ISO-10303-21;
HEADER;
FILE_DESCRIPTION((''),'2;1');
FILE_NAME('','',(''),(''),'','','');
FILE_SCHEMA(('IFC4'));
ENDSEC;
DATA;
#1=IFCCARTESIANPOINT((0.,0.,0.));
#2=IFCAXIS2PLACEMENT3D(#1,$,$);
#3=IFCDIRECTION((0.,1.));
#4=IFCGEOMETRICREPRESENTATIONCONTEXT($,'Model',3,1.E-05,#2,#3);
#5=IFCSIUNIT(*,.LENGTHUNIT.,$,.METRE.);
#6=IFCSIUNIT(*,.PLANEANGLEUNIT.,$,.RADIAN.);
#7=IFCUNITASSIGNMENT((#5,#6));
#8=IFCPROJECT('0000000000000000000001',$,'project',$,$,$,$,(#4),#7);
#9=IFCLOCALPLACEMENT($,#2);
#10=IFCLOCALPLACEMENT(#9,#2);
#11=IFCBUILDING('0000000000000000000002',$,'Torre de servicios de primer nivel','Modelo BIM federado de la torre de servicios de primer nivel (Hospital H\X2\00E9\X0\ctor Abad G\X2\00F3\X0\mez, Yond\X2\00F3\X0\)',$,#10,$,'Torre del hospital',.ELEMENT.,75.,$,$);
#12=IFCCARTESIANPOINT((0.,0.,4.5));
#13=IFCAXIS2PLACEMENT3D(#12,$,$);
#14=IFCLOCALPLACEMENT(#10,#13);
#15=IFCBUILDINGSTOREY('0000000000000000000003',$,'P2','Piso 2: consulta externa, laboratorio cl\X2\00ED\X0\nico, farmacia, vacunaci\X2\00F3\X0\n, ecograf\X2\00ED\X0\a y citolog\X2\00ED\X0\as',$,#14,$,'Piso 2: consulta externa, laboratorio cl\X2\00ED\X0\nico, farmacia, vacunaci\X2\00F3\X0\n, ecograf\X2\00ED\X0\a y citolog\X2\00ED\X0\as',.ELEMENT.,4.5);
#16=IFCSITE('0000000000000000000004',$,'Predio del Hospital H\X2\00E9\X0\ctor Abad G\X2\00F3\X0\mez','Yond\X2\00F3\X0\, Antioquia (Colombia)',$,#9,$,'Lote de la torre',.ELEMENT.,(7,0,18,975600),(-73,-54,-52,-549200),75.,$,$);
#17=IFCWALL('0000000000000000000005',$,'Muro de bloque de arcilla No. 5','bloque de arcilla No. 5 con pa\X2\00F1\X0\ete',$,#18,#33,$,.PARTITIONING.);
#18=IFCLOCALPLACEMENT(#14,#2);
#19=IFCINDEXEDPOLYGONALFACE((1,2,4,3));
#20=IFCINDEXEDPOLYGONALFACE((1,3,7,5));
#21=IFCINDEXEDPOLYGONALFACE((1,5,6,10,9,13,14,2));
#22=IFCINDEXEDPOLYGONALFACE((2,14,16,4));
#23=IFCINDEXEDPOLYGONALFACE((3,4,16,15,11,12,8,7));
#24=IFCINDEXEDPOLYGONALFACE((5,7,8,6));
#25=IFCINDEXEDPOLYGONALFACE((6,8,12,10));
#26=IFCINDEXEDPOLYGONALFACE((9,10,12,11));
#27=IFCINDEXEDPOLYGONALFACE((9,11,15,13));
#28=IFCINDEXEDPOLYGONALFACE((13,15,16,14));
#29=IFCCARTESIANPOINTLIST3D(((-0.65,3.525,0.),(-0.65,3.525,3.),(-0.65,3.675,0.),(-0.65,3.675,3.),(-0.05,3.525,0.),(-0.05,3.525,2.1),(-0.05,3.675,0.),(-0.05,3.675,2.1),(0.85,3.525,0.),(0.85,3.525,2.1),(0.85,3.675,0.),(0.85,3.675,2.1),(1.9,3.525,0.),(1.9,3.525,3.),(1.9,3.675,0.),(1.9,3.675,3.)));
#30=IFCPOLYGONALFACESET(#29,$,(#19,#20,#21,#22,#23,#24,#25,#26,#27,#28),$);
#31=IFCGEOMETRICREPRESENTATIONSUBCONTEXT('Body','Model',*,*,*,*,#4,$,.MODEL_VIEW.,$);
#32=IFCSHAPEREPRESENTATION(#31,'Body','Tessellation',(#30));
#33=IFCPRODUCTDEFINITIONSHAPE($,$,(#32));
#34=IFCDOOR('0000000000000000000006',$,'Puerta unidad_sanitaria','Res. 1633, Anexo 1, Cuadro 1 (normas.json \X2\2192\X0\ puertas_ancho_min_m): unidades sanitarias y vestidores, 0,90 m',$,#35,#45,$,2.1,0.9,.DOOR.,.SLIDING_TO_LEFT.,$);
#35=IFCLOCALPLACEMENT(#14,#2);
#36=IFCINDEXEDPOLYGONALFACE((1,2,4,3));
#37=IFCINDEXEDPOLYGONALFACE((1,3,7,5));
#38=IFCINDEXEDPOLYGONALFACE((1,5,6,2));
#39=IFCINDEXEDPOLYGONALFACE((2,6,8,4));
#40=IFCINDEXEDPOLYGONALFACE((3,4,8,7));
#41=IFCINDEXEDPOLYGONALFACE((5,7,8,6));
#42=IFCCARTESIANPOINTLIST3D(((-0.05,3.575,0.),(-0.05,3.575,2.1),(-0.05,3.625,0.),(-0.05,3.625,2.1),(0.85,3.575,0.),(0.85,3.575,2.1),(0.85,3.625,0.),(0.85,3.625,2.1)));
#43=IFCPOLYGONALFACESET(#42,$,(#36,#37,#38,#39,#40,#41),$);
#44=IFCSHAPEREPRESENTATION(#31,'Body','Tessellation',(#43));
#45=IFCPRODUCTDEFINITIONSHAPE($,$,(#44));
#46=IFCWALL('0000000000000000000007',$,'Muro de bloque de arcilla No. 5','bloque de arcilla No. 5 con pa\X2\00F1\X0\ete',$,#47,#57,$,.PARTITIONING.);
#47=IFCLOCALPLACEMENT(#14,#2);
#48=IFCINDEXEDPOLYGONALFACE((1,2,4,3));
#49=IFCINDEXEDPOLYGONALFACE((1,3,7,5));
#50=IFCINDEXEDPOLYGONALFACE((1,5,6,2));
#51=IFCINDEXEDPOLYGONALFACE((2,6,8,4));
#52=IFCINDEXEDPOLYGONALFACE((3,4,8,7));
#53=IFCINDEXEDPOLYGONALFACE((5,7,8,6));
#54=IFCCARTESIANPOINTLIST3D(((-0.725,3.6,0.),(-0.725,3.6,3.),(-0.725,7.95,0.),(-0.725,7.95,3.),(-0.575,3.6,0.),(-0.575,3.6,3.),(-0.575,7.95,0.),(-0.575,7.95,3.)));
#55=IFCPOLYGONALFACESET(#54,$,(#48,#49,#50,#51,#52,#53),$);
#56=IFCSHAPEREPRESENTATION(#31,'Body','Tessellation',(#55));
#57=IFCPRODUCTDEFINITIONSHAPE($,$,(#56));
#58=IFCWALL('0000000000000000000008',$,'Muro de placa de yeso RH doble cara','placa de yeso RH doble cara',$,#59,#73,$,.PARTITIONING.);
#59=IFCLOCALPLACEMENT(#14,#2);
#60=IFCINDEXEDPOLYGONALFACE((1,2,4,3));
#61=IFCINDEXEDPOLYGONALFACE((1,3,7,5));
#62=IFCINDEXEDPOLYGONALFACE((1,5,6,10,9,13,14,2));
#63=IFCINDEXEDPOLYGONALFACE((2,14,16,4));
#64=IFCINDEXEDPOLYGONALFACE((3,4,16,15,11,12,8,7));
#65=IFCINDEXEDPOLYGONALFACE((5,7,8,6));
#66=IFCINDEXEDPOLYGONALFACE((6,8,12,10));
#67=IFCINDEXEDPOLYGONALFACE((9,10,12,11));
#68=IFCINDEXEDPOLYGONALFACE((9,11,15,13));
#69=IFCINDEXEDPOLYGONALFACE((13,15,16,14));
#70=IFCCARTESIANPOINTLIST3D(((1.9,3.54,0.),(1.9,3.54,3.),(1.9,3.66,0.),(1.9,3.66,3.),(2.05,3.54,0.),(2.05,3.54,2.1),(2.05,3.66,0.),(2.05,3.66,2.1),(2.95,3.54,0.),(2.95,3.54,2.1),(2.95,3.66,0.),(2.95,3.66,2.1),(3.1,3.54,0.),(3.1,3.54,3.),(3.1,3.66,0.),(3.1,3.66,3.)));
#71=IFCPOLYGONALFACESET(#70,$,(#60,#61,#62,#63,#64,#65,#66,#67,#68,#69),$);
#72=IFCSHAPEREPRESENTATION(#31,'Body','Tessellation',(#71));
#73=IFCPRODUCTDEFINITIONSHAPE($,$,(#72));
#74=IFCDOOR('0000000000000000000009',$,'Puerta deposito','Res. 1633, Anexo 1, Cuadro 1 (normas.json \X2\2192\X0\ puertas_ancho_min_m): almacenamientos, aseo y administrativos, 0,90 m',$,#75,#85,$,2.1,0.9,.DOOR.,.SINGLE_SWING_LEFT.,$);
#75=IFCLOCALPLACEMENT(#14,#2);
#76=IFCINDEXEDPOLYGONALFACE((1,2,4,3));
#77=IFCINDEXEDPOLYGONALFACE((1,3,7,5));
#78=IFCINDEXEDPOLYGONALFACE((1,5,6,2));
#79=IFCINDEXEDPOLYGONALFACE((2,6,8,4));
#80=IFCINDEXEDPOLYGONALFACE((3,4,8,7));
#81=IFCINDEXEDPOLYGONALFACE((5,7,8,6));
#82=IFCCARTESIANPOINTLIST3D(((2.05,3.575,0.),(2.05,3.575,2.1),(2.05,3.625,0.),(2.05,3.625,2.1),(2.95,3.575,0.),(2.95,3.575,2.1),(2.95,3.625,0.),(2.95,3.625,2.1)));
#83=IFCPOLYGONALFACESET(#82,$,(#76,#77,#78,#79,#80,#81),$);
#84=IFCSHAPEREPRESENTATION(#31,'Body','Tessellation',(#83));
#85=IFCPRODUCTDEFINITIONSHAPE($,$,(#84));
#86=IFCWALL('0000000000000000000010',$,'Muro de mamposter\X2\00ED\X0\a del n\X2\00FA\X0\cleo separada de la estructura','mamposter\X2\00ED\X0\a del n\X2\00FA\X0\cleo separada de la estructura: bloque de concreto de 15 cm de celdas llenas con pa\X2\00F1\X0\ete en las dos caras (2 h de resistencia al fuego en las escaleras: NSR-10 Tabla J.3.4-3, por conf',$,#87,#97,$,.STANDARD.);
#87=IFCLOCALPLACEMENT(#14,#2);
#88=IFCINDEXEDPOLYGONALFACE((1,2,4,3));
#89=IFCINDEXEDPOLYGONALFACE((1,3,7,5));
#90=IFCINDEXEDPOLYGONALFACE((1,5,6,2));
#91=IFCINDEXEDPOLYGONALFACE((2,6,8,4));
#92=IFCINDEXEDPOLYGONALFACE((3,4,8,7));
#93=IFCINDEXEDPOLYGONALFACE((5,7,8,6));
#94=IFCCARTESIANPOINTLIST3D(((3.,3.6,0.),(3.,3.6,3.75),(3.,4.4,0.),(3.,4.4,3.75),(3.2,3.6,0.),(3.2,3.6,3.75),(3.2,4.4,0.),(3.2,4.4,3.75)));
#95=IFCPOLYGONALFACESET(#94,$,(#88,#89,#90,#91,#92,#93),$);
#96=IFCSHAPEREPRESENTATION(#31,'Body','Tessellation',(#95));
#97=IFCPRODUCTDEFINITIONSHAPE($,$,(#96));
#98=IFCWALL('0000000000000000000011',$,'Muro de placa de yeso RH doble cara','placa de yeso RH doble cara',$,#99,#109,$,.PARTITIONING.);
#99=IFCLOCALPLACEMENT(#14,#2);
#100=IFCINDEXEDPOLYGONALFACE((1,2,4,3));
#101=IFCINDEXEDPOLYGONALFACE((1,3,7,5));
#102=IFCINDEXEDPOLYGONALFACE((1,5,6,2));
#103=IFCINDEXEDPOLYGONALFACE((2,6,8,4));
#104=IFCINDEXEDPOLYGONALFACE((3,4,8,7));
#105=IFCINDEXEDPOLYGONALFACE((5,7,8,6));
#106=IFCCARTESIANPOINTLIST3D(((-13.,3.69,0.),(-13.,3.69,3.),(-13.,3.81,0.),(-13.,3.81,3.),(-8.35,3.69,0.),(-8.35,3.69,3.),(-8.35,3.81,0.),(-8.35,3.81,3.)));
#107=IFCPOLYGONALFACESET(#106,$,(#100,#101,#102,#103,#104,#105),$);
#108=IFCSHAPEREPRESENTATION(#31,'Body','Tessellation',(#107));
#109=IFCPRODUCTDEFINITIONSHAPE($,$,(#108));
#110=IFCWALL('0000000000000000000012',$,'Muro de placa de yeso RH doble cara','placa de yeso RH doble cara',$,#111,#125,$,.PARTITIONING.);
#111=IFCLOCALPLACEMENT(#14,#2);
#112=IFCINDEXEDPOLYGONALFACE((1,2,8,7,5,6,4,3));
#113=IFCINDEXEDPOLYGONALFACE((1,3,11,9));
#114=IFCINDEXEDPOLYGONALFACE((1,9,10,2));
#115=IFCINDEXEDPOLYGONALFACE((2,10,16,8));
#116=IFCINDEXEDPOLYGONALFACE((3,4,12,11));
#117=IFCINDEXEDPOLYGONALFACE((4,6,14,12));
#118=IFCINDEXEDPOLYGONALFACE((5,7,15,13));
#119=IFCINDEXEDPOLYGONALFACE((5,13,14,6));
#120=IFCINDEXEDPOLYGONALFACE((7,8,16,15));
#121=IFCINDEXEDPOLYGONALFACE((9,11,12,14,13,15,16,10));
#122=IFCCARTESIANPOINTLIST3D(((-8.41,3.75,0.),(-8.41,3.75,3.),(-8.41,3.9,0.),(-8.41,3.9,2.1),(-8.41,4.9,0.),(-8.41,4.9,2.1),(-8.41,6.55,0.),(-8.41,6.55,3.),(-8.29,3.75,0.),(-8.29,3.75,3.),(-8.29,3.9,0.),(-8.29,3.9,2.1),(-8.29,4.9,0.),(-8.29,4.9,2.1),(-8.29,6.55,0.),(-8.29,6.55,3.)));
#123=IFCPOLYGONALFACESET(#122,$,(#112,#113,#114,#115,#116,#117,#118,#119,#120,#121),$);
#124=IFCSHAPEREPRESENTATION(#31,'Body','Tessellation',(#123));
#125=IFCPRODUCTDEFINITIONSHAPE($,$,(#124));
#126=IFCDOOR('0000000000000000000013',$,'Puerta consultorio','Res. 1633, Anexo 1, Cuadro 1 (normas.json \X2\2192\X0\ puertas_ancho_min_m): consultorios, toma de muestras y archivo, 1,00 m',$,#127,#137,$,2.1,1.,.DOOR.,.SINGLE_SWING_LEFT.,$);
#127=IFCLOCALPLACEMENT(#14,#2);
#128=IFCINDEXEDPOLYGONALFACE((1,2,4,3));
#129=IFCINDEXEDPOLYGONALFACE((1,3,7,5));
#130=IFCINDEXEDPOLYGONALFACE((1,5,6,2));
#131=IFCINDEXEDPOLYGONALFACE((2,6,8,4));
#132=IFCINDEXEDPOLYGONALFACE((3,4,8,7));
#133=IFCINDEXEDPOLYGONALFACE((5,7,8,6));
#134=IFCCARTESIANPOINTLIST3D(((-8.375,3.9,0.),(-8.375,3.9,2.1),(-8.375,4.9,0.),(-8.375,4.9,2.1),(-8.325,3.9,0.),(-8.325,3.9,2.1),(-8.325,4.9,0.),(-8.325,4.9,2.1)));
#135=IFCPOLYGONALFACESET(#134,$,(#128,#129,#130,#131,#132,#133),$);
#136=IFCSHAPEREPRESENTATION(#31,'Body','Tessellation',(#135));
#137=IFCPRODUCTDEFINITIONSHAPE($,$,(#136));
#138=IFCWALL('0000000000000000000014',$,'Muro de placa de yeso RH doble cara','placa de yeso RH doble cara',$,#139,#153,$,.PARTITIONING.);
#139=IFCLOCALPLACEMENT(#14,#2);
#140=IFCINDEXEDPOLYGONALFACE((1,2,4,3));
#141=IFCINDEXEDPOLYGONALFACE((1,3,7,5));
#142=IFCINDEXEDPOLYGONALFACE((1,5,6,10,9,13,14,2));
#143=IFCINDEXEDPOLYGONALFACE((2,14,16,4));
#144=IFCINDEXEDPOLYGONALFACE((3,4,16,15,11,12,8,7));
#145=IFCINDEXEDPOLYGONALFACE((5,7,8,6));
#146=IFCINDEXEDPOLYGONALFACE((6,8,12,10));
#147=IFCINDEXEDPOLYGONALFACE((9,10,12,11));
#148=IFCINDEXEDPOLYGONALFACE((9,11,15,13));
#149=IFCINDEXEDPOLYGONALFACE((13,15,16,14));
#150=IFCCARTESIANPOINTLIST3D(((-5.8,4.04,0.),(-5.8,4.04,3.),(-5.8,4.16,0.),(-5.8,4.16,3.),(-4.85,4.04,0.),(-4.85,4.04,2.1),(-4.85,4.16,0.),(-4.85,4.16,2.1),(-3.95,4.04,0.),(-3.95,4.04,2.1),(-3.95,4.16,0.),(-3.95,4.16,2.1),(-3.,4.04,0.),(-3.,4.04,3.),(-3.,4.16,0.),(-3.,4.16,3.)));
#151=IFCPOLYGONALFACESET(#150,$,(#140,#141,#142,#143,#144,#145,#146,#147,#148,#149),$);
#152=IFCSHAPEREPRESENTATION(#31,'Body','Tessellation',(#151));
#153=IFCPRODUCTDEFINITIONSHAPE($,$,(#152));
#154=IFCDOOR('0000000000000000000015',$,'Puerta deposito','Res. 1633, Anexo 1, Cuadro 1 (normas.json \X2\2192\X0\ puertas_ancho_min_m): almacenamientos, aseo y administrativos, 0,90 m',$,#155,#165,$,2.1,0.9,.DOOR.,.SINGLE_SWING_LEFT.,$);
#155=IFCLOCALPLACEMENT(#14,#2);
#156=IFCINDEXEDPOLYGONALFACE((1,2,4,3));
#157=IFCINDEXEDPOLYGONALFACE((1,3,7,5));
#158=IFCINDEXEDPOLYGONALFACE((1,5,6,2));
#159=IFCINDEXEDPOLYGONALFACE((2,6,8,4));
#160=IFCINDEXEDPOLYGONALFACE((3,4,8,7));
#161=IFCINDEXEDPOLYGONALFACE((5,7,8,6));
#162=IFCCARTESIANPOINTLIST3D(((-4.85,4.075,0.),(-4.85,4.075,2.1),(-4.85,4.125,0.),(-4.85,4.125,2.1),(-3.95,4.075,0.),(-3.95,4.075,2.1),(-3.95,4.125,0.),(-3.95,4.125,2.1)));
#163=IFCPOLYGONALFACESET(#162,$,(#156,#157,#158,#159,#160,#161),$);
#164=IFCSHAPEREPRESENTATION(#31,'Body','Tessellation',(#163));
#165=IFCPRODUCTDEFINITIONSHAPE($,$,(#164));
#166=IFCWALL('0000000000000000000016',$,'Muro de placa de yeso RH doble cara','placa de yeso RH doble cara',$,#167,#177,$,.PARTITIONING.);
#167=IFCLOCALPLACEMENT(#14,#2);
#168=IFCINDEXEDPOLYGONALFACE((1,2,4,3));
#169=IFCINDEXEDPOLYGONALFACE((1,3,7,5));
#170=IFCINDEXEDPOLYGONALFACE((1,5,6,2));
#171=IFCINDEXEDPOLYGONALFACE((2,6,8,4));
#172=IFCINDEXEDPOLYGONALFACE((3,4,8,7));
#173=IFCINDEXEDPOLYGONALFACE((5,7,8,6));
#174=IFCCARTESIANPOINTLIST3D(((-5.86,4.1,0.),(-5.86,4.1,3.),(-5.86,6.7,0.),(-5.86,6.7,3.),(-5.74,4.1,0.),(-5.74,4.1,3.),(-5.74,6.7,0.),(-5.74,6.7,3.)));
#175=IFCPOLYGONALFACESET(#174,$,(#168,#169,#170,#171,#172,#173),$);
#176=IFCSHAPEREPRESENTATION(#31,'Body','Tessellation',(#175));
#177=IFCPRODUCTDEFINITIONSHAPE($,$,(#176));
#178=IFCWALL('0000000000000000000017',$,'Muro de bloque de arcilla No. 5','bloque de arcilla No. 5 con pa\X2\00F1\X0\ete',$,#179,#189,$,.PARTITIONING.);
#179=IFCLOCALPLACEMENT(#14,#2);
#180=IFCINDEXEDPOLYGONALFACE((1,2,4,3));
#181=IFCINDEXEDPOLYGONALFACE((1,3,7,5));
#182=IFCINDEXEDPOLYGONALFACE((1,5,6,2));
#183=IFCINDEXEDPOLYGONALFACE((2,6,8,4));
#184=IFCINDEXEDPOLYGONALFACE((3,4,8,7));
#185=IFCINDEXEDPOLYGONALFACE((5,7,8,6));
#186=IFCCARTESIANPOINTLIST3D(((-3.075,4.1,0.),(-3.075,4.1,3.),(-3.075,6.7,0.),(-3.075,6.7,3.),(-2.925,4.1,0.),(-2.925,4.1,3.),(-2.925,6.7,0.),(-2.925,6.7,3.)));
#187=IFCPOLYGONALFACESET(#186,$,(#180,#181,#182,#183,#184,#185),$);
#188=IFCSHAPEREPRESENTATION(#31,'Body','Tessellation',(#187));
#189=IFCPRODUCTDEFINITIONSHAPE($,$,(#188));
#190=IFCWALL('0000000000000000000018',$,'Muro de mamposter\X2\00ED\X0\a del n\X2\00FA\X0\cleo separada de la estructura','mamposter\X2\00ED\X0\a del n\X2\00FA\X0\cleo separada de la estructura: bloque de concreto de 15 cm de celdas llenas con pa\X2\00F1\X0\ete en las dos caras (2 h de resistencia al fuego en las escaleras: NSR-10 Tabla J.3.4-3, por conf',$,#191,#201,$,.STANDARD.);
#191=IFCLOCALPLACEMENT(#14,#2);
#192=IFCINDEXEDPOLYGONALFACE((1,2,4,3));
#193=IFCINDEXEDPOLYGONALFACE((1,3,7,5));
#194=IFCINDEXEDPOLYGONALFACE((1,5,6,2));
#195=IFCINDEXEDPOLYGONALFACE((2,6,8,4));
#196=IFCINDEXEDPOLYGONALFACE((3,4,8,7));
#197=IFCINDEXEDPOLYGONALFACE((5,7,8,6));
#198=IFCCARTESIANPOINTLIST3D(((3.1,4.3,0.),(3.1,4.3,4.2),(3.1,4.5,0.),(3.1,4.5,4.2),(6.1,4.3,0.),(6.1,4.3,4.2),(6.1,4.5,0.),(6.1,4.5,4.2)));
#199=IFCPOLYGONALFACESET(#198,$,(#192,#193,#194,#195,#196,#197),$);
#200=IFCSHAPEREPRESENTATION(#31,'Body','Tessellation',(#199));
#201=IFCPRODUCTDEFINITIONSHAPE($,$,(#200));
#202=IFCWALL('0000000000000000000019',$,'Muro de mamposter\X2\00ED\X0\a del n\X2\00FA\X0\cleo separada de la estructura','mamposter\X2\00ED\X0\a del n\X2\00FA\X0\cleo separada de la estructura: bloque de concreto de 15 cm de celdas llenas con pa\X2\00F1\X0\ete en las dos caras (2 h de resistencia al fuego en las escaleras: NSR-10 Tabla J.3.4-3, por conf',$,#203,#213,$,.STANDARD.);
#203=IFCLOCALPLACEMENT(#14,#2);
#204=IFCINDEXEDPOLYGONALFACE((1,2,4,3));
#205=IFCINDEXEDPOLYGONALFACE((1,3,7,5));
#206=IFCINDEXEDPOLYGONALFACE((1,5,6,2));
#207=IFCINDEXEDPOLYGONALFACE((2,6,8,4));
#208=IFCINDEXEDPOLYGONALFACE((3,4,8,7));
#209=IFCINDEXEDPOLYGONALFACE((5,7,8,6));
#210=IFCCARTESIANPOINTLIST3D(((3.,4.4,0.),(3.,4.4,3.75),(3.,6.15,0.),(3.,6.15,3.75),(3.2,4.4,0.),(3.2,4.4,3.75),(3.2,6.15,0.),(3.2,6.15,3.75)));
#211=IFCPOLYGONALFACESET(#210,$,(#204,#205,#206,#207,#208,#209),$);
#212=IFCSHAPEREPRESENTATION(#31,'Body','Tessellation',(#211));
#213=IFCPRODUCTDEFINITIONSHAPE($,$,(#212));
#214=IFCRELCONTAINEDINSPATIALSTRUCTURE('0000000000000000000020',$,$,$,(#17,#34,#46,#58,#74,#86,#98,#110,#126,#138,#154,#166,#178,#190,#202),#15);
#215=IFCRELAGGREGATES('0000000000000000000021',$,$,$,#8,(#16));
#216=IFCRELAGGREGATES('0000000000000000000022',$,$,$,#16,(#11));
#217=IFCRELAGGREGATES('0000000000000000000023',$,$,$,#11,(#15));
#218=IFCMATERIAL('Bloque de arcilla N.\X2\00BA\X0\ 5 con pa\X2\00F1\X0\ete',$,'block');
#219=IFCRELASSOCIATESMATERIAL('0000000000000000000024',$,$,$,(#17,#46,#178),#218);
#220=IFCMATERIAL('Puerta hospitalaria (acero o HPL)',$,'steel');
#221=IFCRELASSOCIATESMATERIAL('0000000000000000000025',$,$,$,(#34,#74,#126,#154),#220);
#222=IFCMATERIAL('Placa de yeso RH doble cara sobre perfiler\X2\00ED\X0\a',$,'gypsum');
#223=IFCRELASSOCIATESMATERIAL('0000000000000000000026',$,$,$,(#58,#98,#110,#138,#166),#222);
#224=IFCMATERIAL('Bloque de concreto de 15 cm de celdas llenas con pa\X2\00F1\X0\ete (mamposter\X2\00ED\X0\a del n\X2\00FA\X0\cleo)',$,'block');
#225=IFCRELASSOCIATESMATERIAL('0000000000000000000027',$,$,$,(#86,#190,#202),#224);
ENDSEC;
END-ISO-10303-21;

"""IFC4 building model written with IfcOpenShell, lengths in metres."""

from ifc_helpers import new_model, si_unit, direction, frame, origin, place, context, subcontext, project, spatial, rectangle, extrude, material, element, fill, save


model = new_model("IFC4")

# Units and contexts
model_context = context("Model", 3, precision=1e-05, world=origin(), true_north=direction((0.0, 1.0)))
body_context = subcontext(model_context, "Body", "Model", "MODEL_VIEW")
ifc_project = project(units=[si_unit("LENGTHUNIT", "METRE"), si_unit("PLANEANGLEUNIT", "RADIAN")], contexts=[model_context])

# Site, building, storey
site_placement = place(None, origin())
site = spatial("IfcSite", under=ifc_project, at=site_placement, Name="Predio del Hospital Héctor Abad Gómez", Description="Yondó, Antioquia (Colombia)", LongName="Lote de la torre", CompositionType="ELEMENT", RefLatitude=(7, 0, 18, 975600), RefLongitude=(-73, -54, -52, -549200), RefElevation=75.0)
building_placement = place(site_placement, origin())
building = spatial("IfcBuilding", under=site, at=building_placement, Name="Torre de servicios de primer nivel", Description="Modelo BIM federado de la torre de servicios de primer nivel (Hospital Héctor Abad Gómez, Yondó)", LongName="Torre del hospital", CompositionType="ELEMENT", ElevationOfRefHeight=75.0)
placement = place(building_placement, frame((0.0, 0.0, 4.5)))
storey = spatial("IfcBuildingStorey", under=building, at=placement, Name="P2", Description="Piso 2: consulta externa, laboratorio clínico, farmacia, vacunación, ecografía y citologías", LongName="Piso 2: consulta externa, laboratorio clínico, farmacia, vacunación, ecografía y citologías", CompositionType="ELEMENT", Elevation=4.5)

# Wall, opening, door
ifc_material_1 = material(Name="Bloque de arcilla N.º 5 con pañete", Category="block")
wall_1 = element("IfcWall", 1, at=placement, inside=storey, material=ifc_material_1, Name="Muro de bloque de arcilla No. 5", Description="bloque de arcilla No. 5 con pañete", PredefinedType="PARTITIONING", context=body_context, shape_type="SweptSolid", body=[
    extrude(rectangle(XDim=2.55, YDim=0.15), frame((0.625, 3.6, 0.0)), (0.0, 0.0, 1.0), 3.0),
])
opening_1 = element("IfcOpeningElement", 2, at=placement, cuts=wall_1, PredefinedType="OPENING", context=body_context, shape_type="SweptSolid", body=[
    extrude(rectangle(XDim=0.9, YDim=0.25), frame((0.4, 3.6, 0.0)), (0.0, 0.0, 1.0), 2.1),
])
ifc_material_2 = material(Name="Puerta hospitalaria (acero o HPL)", Category="steel")
door_1 = element("IfcDoor", 3, at=placement, inside=storey, material=ifc_material_2, Name="Puerta unidad_sanitaria", Description="Res. 1633, Anexo 1, Cuadro 1 (normas.json → puertas_ancho_min_m): unidades sanitarias y vestidores, 0,90 m", OperationType="SLIDING_TO_LEFT", OverallHeight=2.1, OverallWidth=0.9, PredefinedType="DOOR", context=body_context, shape_type="SweptSolid", body=[
    extrude(rectangle(XDim=0.9, YDim=0.05), frame((0.4, 3.6, 0.0)), (0.0, 0.0, 1.0), 2.1),
])
fill(opening_1, door_1)

# Wall
element("IfcWall", 4, at=placement, inside=storey, material=ifc_material_1, Name="Muro de bloque de arcilla No. 5", Description="bloque de arcilla No. 5 con pañete", PredefinedType="PARTITIONING", context=body_context, shape_type="SweptSolid", body=[
    extrude(rectangle(XDim=0.15, YDim=4.35), frame((-0.65, 5.775, 0.0)), (0.0, 0.0, 1.0), 3.0),
])

# Wall, opening, door
ifc_material_3 = material(Name="Placa de yeso RH doble cara sobre perfilería", Category="gypsum")
wall_2 = element("IfcWall", 5, at=placement, inside=storey, material=ifc_material_3, Name="Muro de placa de yeso RH doble cara", Description="placa de yeso RH doble cara", PredefinedType="PARTITIONING", context=body_context, shape_type="SweptSolid", body=[
    extrude(rectangle(XDim=1.2, YDim=0.12), frame((2.5, 3.6, 0.0)), (0.0, 0.0, 1.0), 3.0),
])
opening_2 = element("IfcOpeningElement", 6, at=placement, cuts=wall_2, PredefinedType="OPENING", context=body_context, shape_type="SweptSolid", body=[
    extrude(rectangle(XDim=0.9, YDim=0.22), frame((2.5, 3.6, 0.0)), (0.0, 0.0, 1.0), 2.1),
])
door_2 = element("IfcDoor", 7, at=placement, inside=storey, material=ifc_material_2, Name="Puerta deposito", Description="Res. 1633, Anexo 1, Cuadro 1 (normas.json → puertas_ancho_min_m): almacenamientos, aseo y administrativos, 0,90 m", OperationType="SINGLE_SWING_LEFT", OverallHeight=2.1, OverallWidth=0.9, PredefinedType="DOOR", context=body_context, shape_type="SweptSolid", body=[
    extrude(rectangle(XDim=0.9, YDim=0.05), frame((2.5, 3.6, 0.0)), (0.0, 0.0, 1.0), 2.1),
])
fill(opening_2, door_2)

# Walls
ifc_material_4 = material(Name="Bloque de concreto de 15 cm de celdas llenas con pañete (mampostería del núcleo)", Category="block")
element("IfcWall", 8, at=placement, inside=storey, material=ifc_material_4, Name="Muro de mampostería del núcleo separada de la estructura", Description="mampostería del núcleo separada de la estructura: bloque de concreto de 15 cm de celdas llenas con pañete en las dos caras (2 h de resistencia al fuego en las escaleras: NSR-10 Tabla J.3.4-3, por conf", PredefinedType="STANDARD", context=body_context, shape_type="SweptSolid", body=[
    extrude(rectangle(XDim=0.2, YDim=0.8), frame((3.1, 4.0, 0.0)), (0.0, 0.0, 1.0), 3.75),
])
element("IfcWall", 9, at=placement, inside=storey, material=ifc_material_3, Name="Muro de placa de yeso RH doble cara", Description="placa de yeso RH doble cara", PredefinedType="PARTITIONING", context=body_context, shape_type="SweptSolid", body=[
    extrude(rectangle(XDim=4.65, YDim=0.12), frame((-10.675, 3.75, 0.0)), (0.0, 0.0, 1.0), 3.0),
])

# Walls, openings, doors
wall_3 = element("IfcWall", 10, at=placement, inside=storey, material=ifc_material_3, Name="Muro de placa de yeso RH doble cara", Description="placa de yeso RH doble cara", PredefinedType="PARTITIONING", context=body_context, shape_type="SweptSolid", body=[
    extrude(rectangle(XDim=0.12, YDim=2.8), frame((-8.35, 5.15, 0.0)), (0.0, 0.0, 1.0), 3.0),
])
opening_3 = element("IfcOpeningElement", 11, at=placement, cuts=wall_3, PredefinedType="OPENING", context=body_context, shape_type="SweptSolid", body=[
    extrude(rectangle(XDim=0.22, YDim=1.0), frame((-8.35, 4.4, 0.0)), (0.0, 0.0, 1.0), 2.1),
])
door_3 = element("IfcDoor", 12, at=placement, inside=storey, material=ifc_material_2, Name="Puerta consultorio", Description="Res. 1633, Anexo 1, Cuadro 1 (normas.json → puertas_ancho_min_m): consultorios, toma de muestras y archivo, 1,00 m", OperationType="SINGLE_SWING_LEFT", OverallHeight=2.1, OverallWidth=1.0, PredefinedType="DOOR", context=body_context, shape_type="SweptSolid", body=[
    extrude(rectangle(XDim=0.05, YDim=1.0), frame((-8.35, 4.4, 0.0)), (0.0, 0.0, 1.0), 2.1),
])
fill(opening_3, door_3)
wall_4 = element("IfcWall", 13, at=placement, inside=storey, material=ifc_material_3, Name="Muro de placa de yeso RH doble cara", Description="placa de yeso RH doble cara", PredefinedType="PARTITIONING", context=body_context, shape_type="SweptSolid", body=[
    extrude(rectangle(XDim=2.8, YDim=0.12), frame((-4.4, 4.1, 0.0)), (0.0, 0.0, 1.0), 3.0),
])
opening_4 = element("IfcOpeningElement", 14, at=placement, cuts=wall_4, PredefinedType="OPENING", context=body_context, shape_type="SweptSolid", body=[
    extrude(rectangle(XDim=0.9, YDim=0.22), frame((-4.4, 4.1, 0.0)), (0.0, 0.0, 1.0), 2.1),
])
door_4 = element("IfcDoor", 15, at=placement, inside=storey, material=ifc_material_2, Name="Puerta deposito", Description="Res. 1633, Anexo 1, Cuadro 1 (normas.json → puertas_ancho_min_m): almacenamientos, aseo y administrativos, 0,90 m", OperationType="SINGLE_SWING_LEFT", OverallHeight=2.1, OverallWidth=0.9, PredefinedType="DOOR", context=body_context, shape_type="SweptSolid", body=[
    extrude(rectangle(XDim=0.9, YDim=0.05), frame((-4.4, 4.1, 0.0)), (0.0, 0.0, 1.0), 2.1),
])
fill(opening_4, door_4)

# Walls
element("IfcWall", 16, at=placement, inside=storey, material=ifc_material_3, Name="Muro de placa de yeso RH doble cara", Description="placa de yeso RH doble cara", PredefinedType="PARTITIONING", context=body_context, shape_type="SweptSolid", body=[
    extrude(rectangle(XDim=0.12, YDim=2.6), frame((-5.8, 5.4, 0.0)), (0.0, 0.0, 1.0), 3.0),
])
element("IfcWall", 17, at=placement, inside=storey, material=ifc_material_1, Name="Muro de bloque de arcilla No. 5", Description="bloque de arcilla No. 5 con pañete", PredefinedType="PARTITIONING", context=body_context, shape_type="SweptSolid", body=[
    extrude(rectangle(XDim=0.15, YDim=2.6), frame((-3.0, 5.4, 0.0)), (0.0, 0.0, 1.0), 3.0),
])
element("IfcWall", 18, at=placement, inside=storey, material=ifc_material_4, Name="Muro de mampostería del núcleo separada de la estructura", Description="mampostería del núcleo separada de la estructura: bloque de concreto de 15 cm de celdas llenas con pañete en las dos caras (2 h de resistencia al fuego en las escaleras: NSR-10 Tabla J.3.4-3, por conf", PredefinedType="STANDARD", context=body_context, shape_type="SweptSolid", body=[
    extrude(rectangle(XDim=3.0, YDim=0.2), frame((4.6, 4.4, 0.0)), (0.0, 0.0, 1.0), 4.2),
])
element("IfcWall", 19, at=placement, inside=storey, material=ifc_material_4, Name="Muro de mampostería del núcleo separada de la estructura", Description="mampostería del núcleo separada de la estructura: bloque de concreto de 15 cm de celdas llenas con pañete en las dos caras (2 h de resistencia al fuego en las escaleras: NSR-10 Tabla J.3.4-3, por conf", PredefinedType="STANDARD", context=body_context, shape_type="SweptSolid", body=[
    extrude(rectangle(XDim=0.2, YDim=1.75), frame((3.1, 5.275, 0.0)), (0.0, 0.0, 1.0), 3.75),
])

save(model, "model.ifc")
